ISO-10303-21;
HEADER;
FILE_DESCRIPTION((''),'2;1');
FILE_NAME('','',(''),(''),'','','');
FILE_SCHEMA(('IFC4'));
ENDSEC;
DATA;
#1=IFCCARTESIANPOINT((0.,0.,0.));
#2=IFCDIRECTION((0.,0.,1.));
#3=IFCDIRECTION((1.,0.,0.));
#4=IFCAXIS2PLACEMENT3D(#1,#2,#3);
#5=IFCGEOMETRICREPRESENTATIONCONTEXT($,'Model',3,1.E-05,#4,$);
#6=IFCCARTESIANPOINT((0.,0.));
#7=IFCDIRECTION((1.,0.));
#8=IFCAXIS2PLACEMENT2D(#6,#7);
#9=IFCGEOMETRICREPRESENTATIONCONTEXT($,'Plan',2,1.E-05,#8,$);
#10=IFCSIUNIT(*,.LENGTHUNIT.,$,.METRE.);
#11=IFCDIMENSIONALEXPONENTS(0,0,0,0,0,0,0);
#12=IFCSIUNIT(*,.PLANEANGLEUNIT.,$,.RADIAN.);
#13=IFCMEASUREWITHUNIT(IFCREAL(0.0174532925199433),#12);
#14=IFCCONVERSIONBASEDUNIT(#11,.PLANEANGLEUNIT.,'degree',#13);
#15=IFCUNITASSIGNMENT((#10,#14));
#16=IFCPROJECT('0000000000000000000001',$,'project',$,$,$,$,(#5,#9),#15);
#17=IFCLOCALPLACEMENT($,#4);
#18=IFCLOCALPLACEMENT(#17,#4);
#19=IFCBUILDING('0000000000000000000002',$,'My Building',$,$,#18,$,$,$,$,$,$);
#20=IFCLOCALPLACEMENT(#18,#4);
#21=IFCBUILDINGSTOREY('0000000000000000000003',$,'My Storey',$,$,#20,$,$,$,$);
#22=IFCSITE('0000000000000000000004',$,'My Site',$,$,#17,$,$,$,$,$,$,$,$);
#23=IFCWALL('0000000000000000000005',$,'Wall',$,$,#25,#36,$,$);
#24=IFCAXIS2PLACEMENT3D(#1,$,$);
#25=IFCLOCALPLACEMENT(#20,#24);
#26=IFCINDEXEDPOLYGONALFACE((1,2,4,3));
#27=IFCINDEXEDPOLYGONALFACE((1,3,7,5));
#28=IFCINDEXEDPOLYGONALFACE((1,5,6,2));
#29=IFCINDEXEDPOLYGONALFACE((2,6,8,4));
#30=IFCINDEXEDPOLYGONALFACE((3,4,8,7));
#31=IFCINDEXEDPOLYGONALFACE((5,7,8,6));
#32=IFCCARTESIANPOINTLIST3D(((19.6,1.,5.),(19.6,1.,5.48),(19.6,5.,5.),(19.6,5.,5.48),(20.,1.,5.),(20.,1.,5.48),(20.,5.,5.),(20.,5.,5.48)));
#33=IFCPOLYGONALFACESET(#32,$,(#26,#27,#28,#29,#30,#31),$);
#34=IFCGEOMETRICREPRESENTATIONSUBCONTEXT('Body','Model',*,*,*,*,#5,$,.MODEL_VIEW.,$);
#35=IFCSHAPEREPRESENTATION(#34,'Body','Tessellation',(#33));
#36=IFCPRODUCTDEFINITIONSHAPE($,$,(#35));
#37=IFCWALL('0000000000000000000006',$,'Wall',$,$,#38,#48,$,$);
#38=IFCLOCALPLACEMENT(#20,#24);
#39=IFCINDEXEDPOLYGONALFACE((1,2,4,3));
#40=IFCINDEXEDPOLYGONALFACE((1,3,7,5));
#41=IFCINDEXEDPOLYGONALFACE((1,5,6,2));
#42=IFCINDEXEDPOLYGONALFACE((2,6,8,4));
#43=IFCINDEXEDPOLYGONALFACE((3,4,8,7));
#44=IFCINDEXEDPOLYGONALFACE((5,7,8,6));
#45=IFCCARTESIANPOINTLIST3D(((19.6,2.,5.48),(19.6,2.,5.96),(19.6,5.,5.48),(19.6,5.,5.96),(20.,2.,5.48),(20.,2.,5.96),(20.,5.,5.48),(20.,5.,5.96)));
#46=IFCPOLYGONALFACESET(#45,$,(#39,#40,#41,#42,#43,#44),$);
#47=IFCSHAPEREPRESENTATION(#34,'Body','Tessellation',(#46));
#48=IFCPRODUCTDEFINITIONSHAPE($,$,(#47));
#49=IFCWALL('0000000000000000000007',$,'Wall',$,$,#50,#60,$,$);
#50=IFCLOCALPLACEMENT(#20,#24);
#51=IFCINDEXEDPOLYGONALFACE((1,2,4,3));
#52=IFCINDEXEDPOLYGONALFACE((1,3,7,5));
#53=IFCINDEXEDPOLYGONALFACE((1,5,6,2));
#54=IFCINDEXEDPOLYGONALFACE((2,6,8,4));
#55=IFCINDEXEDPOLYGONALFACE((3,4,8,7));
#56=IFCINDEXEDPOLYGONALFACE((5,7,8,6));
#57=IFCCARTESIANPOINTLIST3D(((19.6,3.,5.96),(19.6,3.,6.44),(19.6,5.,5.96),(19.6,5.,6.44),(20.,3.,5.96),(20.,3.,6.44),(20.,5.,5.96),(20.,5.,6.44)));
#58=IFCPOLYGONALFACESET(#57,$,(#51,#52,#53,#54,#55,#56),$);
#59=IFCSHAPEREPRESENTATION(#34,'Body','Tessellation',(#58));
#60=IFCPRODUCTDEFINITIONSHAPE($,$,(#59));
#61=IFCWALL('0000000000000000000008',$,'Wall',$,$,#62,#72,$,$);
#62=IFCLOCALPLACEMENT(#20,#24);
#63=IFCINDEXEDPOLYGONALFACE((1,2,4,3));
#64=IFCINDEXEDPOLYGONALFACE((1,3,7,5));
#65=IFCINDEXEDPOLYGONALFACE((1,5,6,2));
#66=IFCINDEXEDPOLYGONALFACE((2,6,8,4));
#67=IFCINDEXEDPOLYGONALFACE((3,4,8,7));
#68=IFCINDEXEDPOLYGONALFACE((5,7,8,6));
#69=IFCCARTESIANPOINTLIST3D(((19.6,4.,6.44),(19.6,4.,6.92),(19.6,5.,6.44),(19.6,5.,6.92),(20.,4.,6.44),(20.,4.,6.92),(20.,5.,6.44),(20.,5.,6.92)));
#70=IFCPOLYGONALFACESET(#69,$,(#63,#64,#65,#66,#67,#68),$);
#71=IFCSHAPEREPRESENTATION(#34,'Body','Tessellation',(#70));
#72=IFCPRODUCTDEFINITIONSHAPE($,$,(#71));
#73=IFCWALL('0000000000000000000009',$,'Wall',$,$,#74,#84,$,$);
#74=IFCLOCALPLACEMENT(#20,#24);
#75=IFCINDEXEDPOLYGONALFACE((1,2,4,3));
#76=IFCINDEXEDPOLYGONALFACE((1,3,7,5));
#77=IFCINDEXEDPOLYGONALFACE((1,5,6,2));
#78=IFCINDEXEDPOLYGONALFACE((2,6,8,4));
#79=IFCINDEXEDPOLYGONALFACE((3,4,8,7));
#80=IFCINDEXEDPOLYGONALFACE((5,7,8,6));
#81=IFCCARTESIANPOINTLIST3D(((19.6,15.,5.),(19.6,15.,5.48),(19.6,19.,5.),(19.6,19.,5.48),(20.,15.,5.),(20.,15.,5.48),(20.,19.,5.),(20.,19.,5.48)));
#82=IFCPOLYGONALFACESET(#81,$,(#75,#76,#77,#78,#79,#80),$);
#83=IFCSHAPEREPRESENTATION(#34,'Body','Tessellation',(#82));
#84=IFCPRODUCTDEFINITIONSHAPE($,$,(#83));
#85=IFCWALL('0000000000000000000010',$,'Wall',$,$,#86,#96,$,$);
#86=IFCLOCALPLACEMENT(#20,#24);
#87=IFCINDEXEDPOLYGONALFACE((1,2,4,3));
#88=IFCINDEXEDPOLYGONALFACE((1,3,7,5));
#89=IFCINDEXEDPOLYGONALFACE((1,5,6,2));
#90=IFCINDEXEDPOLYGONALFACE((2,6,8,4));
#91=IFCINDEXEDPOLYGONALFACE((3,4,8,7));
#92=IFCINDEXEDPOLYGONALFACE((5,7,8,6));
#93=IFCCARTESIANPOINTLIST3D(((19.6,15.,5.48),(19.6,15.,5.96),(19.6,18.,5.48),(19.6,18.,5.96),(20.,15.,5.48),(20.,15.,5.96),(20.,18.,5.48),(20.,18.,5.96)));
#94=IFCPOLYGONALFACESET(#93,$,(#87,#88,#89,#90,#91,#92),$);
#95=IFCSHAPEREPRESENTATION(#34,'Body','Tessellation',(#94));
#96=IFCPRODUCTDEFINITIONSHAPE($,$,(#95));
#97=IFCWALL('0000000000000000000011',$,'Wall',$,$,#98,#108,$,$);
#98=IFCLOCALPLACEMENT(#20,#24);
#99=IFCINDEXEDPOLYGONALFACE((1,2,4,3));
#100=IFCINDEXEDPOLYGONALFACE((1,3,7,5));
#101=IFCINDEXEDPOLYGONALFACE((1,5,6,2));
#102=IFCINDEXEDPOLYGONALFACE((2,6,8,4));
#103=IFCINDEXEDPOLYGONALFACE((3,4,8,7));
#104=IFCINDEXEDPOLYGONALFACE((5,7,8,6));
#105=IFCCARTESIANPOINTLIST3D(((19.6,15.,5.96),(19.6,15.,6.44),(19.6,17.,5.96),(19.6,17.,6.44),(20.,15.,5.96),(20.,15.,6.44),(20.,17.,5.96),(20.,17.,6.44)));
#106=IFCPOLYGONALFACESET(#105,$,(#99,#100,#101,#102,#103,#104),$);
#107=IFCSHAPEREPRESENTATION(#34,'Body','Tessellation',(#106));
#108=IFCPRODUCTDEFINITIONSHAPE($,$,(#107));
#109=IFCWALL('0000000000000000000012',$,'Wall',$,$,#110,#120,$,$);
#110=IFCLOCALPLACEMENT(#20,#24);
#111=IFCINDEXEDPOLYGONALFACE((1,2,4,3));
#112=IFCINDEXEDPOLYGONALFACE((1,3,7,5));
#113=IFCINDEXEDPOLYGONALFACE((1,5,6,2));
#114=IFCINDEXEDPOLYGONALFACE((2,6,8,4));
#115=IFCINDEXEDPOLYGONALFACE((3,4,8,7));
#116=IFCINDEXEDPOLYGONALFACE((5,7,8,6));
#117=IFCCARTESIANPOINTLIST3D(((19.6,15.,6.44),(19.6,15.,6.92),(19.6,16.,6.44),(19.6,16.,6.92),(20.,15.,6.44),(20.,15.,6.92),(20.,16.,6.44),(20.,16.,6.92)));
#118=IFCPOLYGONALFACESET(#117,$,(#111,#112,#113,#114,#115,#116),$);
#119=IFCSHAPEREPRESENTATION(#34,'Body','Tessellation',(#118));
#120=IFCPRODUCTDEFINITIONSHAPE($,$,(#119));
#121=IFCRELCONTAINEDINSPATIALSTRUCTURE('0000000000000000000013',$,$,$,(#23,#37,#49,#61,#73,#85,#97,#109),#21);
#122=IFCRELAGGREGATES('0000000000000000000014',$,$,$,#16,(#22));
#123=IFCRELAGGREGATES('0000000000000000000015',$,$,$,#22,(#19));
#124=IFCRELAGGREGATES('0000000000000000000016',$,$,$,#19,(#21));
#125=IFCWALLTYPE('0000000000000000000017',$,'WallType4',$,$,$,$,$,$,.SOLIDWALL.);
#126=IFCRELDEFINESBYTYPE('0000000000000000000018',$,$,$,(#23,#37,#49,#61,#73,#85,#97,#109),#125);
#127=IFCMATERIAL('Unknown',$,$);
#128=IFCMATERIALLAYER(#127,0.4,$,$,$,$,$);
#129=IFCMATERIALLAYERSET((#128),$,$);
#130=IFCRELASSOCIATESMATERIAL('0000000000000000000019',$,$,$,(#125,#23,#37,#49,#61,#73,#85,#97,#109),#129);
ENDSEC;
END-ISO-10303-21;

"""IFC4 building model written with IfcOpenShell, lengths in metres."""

from ifc_helpers import new_model, entity, si_unit, converted_unit, frame, origin_with_axes, origin_2d_with_axis, place, context, subcontext, project, spatial, indexed_curve, outline, extrude, material, layer, layer_set, layer_usage, type_object, element, save


model = new_model("IFC4")

# Units and contexts
model_context = context("Model", 3, precision=1e-05, world=origin_with_axes())
plan_context = context("Plan", 2, precision=1e-05, world=origin_2d_with_axis())
body_context_1 = subcontext(model_context, "Body", "Model", "MODEL_VIEW")
ifc_project = project(units=[si_unit("LENGTHUNIT", "METRE"), converted_unit("PLANEANGLEUNIT", "degree", entity("IfcReal", 0.0174532925199433), si_unit("PLANEANGLEUNIT", "RADIAN"), dimensions=[0, 0, 0, 0, 0, 0, 0])], contexts=[model_context, plan_context])

# Site, building, storey
site_placement = place(None, origin_with_axes())
site = spatial("IfcSite", under=ifc_project, at=site_placement, Name="My Site")
building_placement = place(site_placement, origin_with_axes())
building = spatial("IfcBuilding", under=site, at=building_placement, Name="My Building")
storey_placement = place(building_placement, origin_with_axes())
storey = spatial("IfcBuildingStorey", under=building, at=storey_placement, Name="My Storey")

# Shared definitions
ifc_material = material(Name="Unknown")

# Shared definitions
ifc_layer_1 = layer(ifc_material, 0.4)
ifc_layer_set_1 = layer_set([ifc_layer_1])
wall_type_1 = type_object("IfcWallType", Name="WallType4", PredefinedType="SOLIDWALL", material=ifc_layer_set_1)

# Walls
ifc_layer_usage_1 = layer_usage(ifc_layer_set_1, "AXIS2", "POSITIVE", 0.0)
wall_1_placement = place(storey_placement, frame((20.0, 1.0, 5.0), z_axis=(0.0, 0.0, 1.0), x_axis=(0.0, 1.0, 0.0)))
element("IfcWall", 1, at=wall_1_placement, inside=storey, type_object=wall_type_1, material=ifc_layer_usage_1, Name="Wall", context=body_context_1, shape_type="SweptSolid", body=[
    extrude(outline(indexed_curve([(0.0, 0.0), (0.0, 0.4), (4.0, 0.4), (4.0, 0.0), (0.0, 0.0)], self_intersect=False)), origin_with_axes(), (0.0, 0.0, 1.0), 0.48),
])
ifc_layer_usage_2 = layer_usage(ifc_layer_set_1, "AXIS2", "POSITIVE", 0.0)
wall_2_placement = place(storey_placement, frame((20.0, 2.0, 5.48), z_axis=(0.0, 0.0, 1.0), x_axis=(0.0, 1.0, 0.0)))
element("IfcWall", 2, at=wall_2_placement, inside=storey, type_object=wall_type_1, material=ifc_layer_usage_2, Name="Wall", context=body_context_1, shape_type="SweptSolid", body=[
    extrude(outline(indexed_curve([(0.0, 0.0), (0.0, 0.4), (3.0, 0.4), (3.0, 0.0), (0.0, 0.0)], self_intersect=False)), origin_with_axes(), (0.0, 0.0, 1.0), 0.48),
])
ifc_layer_usage_3 = layer_usage(ifc_layer_set_1, "AXIS2", "POSITIVE", 0.0)
wall_3_placement = place(storey_placement, frame((20.0, 3.0, 5.96), z_axis=(0.0, 0.0, 1.0), x_axis=(0.0, 1.0, 0.0)))
element("IfcWall", 3, at=wall_3_placement, inside=storey, type_object=wall_type_1, material=ifc_layer_usage_3, Name="Wall", context=body_context_1, shape_type="SweptSolid", body=[
    extrude(outline(indexed_curve([(0.0, 0.0), (0.0, 0.4), (2.0, 0.4), (2.0, 0.0), (0.0, 0.0)], self_intersect=False)), origin_with_axes(), (0.0, 0.0, 1.0), 0.48),
])
ifc_layer_usage_4 = layer_usage(ifc_layer_set_1, "AXIS2", "POSITIVE", 0.0)
wall_4_placement = place(storey_placement, frame((20.0, 4.0, 6.44), z_axis=(0.0, 0.0, 1.0), x_axis=(0.0, 1.0, 0.0)))
element("IfcWall", 4, at=wall_4_placement, inside=storey, type_object=wall_type_1, material=ifc_layer_usage_4, Name="Wall", context=body_context_1, shape_type="SweptSolid", body=[
    extrude(outline(indexed_curve([(0.0, 0.0), (0.0, 0.4), (1.0, 0.4), (1.0, 0.0), (0.0, 0.0)], self_intersect=False)), origin_with_axes(), (0.0, 0.0, 1.0), 0.48),
])
ifc_layer_usage_5 = layer_usage(ifc_layer_set_1, "AXIS2", "POSITIVE", 0.0)
wall_5_placement = place(storey_placement, frame((20.0, 15.0, 5.0), z_axis=(0.0, 0.0, 1.0), x_axis=(0.0, 1.0, 0.0)))
element("IfcWall", 5, at=wall_5_placement, inside=storey, type_object=wall_type_1, material=ifc_layer_usage_5, Name="Wall", context=body_context_1, shape_type="SweptSolid", body=[
    extrude(outline(indexed_curve([(0.0, 0.0), (0.0, 0.4), (4.0, 0.4), (4.0, 0.0), (0.0, 0.0)], self_intersect=False)), origin_with_axes(), (0.0, 0.0, 1.0), 0.48),
])
ifc_layer_usage_6 = layer_usage(ifc_layer_set_1, "AXIS2", "POSITIVE", 0.0)
wall_6_placement = place(storey_placement, frame((20.0, 15.0, 5.48), z_axis=(0.0, 0.0, 1.0), x_axis=(0.0, 1.0, 0.0)))
element("IfcWall", 6, at=wall_6_placement, inside=storey, type_object=wall_type_1, material=ifc_layer_usage_6, Name="Wall", context=body_context_1, shape_type="SweptSolid", body=[
    extrude(outline(indexed_curve([(0.0, 0.0), (0.0, 0.4), (3.0, 0.4), (3.0, 0.0), (0.0, 0.0)], self_intersect=False)), origin_with_axes(), (0.0, 0.0, 1.0), 0.48),
])
ifc_layer_usage_7 = layer_usage(ifc_layer_set_1, "AXIS2", "POSITIVE", 0.0)
wall_7_placement = place(storey_placement, frame((20.0, 15.0, 5.96), z_axis=(0.0, 0.0, 1.0), x_axis=(0.0, 1.0, 0.0)))
element("IfcWall", 7, at=wall_7_placement, inside=storey, type_object=wall_type_1, material=ifc_layer_usage_7, Name="Wall", context=body_context_1, shape_type="SweptSolid", body=[
    extrude(outline(indexed_curve([(0.0, 0.0), (0.0, 0.4), (2.0, 0.4), (2.0, 0.0), (0.0, 0.0)], self_intersect=False)), origin_with_axes(), (0.0, 0.0, 1.0), 0.48),
])
ifc_layer_usage_8 = layer_usage(ifc_layer_set_1, "AXIS2", "POSITIVE", 0.0)
wall_8_placement = place(storey_placement, frame((20.0, 15.0, 6.44), z_axis=(0.0, 0.0, 1.0), x_axis=(0.0, 1.0, 0.0)))
element("IfcWall", 8, at=wall_8_placement, inside=storey, type_object=wall_type_1, material=ifc_layer_usage_8, Name="Wall", context=body_context_1, shape_type="SweptSolid", body=[
    extrude(outline(indexed_curve([(0.0, 0.0), (0.0, 0.4), (1.0, 0.4), (1.0, 0.0), (0.0, 0.0)], self_intersect=False)), origin_with_axes(), (0.0, 0.0, 1.0), 0.48),
])

save(model, "model.ifc")
